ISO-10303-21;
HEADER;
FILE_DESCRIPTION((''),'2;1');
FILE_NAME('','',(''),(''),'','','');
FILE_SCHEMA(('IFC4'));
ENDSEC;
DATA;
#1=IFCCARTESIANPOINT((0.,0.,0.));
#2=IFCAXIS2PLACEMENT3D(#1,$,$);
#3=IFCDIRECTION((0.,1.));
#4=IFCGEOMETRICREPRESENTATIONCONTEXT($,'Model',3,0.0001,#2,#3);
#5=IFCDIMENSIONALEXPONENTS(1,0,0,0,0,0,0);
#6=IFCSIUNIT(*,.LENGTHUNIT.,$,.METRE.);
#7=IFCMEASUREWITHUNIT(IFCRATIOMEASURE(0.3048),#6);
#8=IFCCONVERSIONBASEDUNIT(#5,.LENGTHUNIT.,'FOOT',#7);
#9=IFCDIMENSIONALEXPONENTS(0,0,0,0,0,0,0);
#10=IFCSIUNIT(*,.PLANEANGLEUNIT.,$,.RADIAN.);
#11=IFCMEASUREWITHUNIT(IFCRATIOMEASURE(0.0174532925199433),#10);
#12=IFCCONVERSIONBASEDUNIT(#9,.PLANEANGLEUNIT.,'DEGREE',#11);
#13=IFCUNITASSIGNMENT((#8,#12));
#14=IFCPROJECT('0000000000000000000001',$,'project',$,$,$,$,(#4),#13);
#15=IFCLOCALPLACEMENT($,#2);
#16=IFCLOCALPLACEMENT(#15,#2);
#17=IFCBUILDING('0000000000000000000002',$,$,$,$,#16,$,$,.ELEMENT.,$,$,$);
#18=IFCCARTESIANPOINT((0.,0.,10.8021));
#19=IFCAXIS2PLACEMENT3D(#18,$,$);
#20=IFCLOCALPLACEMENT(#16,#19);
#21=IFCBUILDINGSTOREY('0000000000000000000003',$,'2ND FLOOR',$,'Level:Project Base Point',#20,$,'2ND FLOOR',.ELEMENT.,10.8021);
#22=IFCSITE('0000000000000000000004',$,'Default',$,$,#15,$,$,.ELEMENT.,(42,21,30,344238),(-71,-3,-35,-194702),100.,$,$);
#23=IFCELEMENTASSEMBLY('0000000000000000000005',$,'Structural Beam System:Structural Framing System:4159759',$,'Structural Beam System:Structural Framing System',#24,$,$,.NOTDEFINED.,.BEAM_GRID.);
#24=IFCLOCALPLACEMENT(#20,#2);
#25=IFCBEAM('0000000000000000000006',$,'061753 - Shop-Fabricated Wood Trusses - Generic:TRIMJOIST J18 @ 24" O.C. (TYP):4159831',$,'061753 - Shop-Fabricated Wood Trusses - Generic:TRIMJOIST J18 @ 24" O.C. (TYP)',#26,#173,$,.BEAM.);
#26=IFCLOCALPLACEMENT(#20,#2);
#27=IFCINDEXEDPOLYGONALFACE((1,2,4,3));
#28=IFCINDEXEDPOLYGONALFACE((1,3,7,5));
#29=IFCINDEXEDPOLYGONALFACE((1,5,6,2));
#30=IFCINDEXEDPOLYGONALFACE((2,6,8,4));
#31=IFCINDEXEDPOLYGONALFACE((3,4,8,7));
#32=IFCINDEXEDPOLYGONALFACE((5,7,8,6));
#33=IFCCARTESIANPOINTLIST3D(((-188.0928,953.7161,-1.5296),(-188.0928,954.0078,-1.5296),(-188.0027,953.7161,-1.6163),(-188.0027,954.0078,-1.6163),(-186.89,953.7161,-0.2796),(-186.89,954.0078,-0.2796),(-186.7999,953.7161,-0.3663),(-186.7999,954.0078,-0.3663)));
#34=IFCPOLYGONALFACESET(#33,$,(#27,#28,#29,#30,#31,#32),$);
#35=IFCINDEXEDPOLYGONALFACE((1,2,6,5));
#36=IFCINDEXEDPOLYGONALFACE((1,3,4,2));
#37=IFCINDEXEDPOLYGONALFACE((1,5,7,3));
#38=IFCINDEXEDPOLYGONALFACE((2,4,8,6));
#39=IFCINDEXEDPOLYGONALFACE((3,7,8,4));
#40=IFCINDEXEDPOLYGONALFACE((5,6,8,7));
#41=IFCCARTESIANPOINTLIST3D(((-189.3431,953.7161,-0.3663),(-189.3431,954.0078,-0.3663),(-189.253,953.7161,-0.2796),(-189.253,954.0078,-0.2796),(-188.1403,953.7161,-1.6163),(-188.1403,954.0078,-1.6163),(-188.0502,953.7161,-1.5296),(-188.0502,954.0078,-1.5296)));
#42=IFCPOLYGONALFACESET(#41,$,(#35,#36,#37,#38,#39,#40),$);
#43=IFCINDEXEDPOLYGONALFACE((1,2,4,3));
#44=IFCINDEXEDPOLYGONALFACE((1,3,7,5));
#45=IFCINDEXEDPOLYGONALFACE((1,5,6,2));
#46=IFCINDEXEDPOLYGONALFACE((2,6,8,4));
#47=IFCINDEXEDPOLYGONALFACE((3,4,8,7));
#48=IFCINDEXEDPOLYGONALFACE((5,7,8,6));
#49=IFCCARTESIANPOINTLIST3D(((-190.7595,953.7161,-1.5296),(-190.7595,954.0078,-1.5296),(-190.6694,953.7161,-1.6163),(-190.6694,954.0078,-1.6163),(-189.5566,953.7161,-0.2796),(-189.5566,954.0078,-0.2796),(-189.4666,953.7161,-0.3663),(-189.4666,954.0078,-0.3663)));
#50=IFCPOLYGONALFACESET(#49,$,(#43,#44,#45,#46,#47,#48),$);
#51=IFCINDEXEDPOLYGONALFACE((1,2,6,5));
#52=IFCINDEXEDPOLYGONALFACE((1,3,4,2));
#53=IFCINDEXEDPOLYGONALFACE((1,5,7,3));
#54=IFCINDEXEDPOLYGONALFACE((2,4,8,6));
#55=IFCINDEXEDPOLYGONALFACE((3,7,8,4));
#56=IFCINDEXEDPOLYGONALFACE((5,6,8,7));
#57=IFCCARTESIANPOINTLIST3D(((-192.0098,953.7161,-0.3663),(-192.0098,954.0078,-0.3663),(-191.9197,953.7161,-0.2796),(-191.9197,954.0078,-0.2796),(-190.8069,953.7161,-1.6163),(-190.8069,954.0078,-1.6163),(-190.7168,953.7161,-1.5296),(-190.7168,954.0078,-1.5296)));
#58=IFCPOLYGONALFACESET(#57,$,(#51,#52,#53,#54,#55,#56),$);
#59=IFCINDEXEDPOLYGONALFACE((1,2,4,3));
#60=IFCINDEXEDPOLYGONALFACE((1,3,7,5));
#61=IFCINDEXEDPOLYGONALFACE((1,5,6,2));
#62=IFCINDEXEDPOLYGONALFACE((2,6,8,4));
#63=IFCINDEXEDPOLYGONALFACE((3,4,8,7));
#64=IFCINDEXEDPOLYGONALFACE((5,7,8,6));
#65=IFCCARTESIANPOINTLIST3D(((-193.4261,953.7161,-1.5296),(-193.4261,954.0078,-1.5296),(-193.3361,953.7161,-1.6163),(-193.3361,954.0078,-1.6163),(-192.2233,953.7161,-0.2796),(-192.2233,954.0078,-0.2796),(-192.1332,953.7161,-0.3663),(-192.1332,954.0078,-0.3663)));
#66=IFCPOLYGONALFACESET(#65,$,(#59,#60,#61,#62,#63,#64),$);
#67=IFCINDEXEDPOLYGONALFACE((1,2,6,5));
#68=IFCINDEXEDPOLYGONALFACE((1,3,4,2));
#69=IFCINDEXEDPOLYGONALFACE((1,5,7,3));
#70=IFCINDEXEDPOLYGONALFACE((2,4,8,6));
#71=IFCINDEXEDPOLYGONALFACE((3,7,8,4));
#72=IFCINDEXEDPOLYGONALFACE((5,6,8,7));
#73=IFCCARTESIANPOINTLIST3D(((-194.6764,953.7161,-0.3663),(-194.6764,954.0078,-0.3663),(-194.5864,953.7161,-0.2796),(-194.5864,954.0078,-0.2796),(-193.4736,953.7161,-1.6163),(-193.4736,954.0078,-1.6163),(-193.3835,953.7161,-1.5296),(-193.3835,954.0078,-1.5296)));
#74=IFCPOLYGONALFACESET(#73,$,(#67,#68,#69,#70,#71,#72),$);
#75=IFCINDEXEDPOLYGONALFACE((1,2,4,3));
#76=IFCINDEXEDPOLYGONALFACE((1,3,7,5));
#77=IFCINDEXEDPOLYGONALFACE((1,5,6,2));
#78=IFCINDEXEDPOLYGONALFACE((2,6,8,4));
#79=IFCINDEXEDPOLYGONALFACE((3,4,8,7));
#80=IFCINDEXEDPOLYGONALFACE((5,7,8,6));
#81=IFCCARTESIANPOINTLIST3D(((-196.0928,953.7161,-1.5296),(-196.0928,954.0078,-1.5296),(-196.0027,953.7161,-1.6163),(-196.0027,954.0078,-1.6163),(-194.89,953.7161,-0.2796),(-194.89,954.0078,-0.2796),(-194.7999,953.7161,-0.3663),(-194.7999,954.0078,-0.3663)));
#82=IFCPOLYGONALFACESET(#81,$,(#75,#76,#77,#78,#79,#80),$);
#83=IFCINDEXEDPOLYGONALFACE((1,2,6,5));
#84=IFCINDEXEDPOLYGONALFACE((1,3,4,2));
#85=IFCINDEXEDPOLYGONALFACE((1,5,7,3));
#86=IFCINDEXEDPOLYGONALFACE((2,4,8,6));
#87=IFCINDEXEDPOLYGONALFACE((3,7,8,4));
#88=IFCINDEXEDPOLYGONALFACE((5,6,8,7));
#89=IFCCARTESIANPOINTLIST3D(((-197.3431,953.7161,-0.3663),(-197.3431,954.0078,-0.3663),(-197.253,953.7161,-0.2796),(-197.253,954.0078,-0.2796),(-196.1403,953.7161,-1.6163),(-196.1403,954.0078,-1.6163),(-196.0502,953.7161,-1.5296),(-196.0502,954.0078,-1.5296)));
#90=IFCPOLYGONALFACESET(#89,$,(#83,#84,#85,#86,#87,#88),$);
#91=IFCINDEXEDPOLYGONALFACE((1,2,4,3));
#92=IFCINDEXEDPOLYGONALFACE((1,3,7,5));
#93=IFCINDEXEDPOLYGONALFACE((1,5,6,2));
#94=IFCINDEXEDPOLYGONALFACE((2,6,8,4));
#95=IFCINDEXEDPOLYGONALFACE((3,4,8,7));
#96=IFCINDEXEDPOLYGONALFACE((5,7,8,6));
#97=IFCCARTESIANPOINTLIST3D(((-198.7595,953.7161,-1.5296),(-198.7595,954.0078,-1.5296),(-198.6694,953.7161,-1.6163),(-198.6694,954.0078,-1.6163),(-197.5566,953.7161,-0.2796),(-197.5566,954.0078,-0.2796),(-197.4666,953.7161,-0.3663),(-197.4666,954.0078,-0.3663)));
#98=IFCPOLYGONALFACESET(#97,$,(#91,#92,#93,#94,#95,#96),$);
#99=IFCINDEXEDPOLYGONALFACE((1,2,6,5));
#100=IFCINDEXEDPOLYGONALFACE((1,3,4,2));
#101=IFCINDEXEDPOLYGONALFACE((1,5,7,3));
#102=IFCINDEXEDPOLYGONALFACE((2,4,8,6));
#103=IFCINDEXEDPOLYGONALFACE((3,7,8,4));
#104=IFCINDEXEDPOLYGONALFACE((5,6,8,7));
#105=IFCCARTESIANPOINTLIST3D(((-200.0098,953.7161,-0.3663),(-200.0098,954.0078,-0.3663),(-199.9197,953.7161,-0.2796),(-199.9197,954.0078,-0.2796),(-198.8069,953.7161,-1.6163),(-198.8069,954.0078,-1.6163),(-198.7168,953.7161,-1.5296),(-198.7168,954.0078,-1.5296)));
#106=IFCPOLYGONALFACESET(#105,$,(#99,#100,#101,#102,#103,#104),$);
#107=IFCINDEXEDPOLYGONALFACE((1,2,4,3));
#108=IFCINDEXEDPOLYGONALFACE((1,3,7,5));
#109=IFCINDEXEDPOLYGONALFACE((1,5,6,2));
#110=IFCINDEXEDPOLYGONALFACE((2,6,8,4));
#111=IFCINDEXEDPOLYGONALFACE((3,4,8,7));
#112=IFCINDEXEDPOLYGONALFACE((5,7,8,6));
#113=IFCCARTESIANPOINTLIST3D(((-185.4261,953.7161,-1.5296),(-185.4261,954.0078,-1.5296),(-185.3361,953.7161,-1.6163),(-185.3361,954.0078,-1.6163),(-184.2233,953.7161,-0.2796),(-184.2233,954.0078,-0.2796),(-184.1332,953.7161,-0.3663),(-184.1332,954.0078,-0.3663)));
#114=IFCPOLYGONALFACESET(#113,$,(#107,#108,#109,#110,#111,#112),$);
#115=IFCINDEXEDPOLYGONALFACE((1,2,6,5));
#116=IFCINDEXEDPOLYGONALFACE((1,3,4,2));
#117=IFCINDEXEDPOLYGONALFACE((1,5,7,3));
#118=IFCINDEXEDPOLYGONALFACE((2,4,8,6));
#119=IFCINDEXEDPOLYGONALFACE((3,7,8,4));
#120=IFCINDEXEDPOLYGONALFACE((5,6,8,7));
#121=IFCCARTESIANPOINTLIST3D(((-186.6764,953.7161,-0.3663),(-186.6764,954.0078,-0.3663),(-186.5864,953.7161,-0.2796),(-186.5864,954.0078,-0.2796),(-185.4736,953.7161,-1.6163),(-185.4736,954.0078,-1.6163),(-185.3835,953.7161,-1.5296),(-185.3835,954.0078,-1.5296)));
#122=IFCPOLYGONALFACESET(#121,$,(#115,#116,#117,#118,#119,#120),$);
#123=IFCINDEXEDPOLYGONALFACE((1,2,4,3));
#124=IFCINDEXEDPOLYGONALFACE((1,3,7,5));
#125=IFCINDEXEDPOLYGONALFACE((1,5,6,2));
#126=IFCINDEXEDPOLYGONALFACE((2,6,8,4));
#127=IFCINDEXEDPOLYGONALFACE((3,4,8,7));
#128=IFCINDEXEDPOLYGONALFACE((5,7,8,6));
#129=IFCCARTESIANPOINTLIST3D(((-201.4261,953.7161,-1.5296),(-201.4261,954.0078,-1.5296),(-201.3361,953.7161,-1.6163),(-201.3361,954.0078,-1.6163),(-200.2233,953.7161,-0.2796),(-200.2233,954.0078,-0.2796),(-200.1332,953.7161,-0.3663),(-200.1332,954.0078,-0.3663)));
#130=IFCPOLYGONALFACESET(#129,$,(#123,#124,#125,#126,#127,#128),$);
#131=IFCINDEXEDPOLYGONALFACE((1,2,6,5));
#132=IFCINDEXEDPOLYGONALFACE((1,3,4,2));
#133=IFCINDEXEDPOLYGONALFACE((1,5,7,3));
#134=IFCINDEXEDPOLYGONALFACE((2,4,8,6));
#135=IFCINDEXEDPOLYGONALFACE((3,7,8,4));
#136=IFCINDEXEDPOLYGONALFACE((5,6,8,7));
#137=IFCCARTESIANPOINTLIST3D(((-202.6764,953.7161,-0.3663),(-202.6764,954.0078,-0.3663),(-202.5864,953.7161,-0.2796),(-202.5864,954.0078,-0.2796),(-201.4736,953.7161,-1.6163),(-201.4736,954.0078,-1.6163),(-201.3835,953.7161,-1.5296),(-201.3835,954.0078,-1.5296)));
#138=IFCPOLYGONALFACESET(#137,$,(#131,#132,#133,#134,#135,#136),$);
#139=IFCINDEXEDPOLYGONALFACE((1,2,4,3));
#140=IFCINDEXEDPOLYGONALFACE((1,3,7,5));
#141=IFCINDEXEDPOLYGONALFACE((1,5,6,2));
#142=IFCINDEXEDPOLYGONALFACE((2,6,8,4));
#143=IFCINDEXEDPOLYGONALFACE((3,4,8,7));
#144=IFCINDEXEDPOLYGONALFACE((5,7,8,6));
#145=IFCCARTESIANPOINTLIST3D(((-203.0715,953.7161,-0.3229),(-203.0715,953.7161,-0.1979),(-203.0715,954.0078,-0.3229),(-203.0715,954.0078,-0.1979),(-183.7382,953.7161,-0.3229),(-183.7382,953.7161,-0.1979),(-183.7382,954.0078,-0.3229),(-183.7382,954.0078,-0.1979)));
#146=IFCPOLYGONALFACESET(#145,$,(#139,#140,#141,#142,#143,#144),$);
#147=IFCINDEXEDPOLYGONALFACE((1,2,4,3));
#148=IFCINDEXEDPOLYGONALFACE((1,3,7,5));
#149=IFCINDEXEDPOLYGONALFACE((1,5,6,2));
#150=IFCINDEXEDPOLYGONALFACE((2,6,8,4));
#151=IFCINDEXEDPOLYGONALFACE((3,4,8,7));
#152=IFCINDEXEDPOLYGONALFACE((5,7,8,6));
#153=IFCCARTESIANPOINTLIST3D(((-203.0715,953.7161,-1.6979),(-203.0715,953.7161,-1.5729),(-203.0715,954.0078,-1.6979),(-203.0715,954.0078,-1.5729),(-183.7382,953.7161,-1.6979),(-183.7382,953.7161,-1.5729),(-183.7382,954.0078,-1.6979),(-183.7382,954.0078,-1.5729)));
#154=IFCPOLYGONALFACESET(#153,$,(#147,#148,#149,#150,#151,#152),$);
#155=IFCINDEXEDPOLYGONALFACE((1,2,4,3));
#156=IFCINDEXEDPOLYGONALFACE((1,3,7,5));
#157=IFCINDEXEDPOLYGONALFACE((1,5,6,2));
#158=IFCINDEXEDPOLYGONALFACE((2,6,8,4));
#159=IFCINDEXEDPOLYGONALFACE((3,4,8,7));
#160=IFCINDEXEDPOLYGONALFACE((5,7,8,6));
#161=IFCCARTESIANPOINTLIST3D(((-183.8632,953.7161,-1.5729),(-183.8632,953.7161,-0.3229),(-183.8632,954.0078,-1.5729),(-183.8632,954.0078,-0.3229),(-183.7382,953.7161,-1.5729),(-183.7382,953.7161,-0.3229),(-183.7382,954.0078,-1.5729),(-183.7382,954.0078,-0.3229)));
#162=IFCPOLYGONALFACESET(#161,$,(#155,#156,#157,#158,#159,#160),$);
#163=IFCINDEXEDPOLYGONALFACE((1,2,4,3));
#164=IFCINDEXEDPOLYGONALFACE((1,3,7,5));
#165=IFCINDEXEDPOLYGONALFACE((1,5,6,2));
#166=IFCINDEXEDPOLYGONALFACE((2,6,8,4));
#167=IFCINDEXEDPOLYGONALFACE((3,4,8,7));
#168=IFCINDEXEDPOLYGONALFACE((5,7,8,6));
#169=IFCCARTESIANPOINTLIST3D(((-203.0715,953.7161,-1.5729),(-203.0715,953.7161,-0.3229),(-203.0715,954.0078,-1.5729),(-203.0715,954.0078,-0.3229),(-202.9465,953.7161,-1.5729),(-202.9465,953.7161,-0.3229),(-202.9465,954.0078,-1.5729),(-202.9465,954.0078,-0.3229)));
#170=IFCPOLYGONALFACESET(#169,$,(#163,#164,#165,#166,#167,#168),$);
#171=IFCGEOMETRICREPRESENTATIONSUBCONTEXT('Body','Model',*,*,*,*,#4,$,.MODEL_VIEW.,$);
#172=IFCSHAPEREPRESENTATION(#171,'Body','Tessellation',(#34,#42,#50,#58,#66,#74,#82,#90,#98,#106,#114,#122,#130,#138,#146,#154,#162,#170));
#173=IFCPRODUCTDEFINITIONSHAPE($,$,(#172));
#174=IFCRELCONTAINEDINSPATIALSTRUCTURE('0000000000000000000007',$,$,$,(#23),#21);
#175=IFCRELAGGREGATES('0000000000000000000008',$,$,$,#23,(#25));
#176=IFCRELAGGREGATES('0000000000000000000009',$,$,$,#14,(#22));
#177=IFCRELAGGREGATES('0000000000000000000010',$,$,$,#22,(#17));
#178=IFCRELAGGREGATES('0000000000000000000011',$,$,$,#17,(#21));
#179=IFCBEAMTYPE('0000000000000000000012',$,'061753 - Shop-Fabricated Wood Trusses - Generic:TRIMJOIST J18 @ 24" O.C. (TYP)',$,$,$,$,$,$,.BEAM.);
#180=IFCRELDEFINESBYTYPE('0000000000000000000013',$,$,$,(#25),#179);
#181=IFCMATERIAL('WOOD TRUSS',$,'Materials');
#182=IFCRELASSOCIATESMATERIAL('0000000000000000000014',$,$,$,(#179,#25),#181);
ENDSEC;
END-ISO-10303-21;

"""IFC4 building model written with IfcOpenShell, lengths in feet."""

from ifc_helpers import new_model, entity, si_unit, converted_unit, direction, frame, frame_2d, origin, origin_2d_with_axis, place, context, subcontext, project, spatial, rectangle, extrude, source, transform, mapped, material, material_profile, profile_set, profile_usage, type_object, type_shapes, element, aggregate, save


model = new_model("IFC4")

# Units and contexts
model_context = context("Model", 3, precision=0.0001, world=origin(), true_north=direction((0.0, 1.0)))
body_context = subcontext(model_context, "Body", "Model", "MODEL_VIEW")
ifc_project = project(units=[converted_unit("LENGTHUNIT", "FOOT", entity("IfcRatioMeasure", 0.3048), si_unit("LENGTHUNIT", "METRE"), dimensions=[1, 0, 0, 0, 0, 0, 0]), converted_unit("PLANEANGLEUNIT", "DEGREE", entity("IfcRatioMeasure", 0.0174532925199433), si_unit("PLANEANGLEUNIT", "RADIAN"), dimensions=[0, 0, 0, 0, 0, 0, 0])], contexts=[model_context])

# Site, building, storey
site_placement = place(None, origin())
site = spatial("IfcSite", under=ifc_project, at=site_placement, Name="Default", CompositionType="ELEMENT", RefLatitude=(42, 21, 30, 344238), RefLongitude=(-71, -3, -35, -194702), RefElevation=100.0)
building_placement = place(site_placement, origin())
building = spatial("IfcBuilding", under=site, at=building_placement, CompositionType="ELEMENT")
storey_placement = place(building_placement, frame((0.0, 0.0, 10.8021)))
storey = spatial("IfcBuildingStorey", under=building, at=storey_placement, Name="2ND FLOOR", ObjectType="Level:Project Base Point", LongName="2ND FLOOR", CompositionType="ELEMENT", Elevation=10.8021)

# Element assembly, beam
ifc_material_1 = material(Name="WOOD TRUSS", Category="Materials")
ifc_material_profile_1 = material_profile(ifc_material_1, rectangle(XDim=1.7347, YDim=0.125, at=frame_2d((0.0, 0.0), x_axis=(1.0, 0.0))), Name="TRIMJOIST J18 @ 24\" O.C. (TYP)")
ifc_material_profile_2 = material_profile(ifc_material_1, rectangle(XDim=1.7347, YDim=0.125, at=frame_2d((0.0, 0.0), x_axis=(1.0, 0.0))), Name="TRIMJOIST J18 @ 24\" O.C. (TYP)")
ifc_material_profile_3 = material_profile(ifc_material_1, rectangle(XDim=1.7347, YDim=0.125, at=frame_2d((0.0, 0.0), x_axis=(1.0, 0.0))), Name="TRIMJOIST J18 @ 24\" O.C. (TYP)")
ifc_material_profile_4 = material_profile(ifc_material_1, rectangle(XDim=1.7347, YDim=0.125, at=frame_2d((0.0, 0.0), x_axis=(1.0, 0.0))), Name="TRIMJOIST J18 @ 24\" O.C. (TYP)")
ifc_material_profile_5 = material_profile(ifc_material_1, rectangle(XDim=1.7347, YDim=0.125, at=frame_2d((0.0, 0.0), x_axis=(1.0, 0.0))), Name="TRIMJOIST J18 @ 24\" O.C. (TYP)")
ifc_material_profile_6 = material_profile(ifc_material_1, rectangle(XDim=1.7347, YDim=0.125, at=frame_2d((0.0, 0.0), x_axis=(1.0, 0.0))), Name="TRIMJOIST J18 @ 24\" O.C. (TYP)")
ifc_material_profile_7 = material_profile(ifc_material_1, rectangle(XDim=1.7347, YDim=0.125, at=frame_2d((0.0, 0.0), x_axis=(1.0, 0.0))), Name="TRIMJOIST J18 @ 24\" O.C. (TYP)")
ifc_material_profile_8 = material_profile(ifc_material_1, rectangle(XDim=1.7347, YDim=0.125, at=frame_2d((0.0, 0.0), x_axis=(1.0, 0.0))), Name="TRIMJOIST J18 @ 24\" O.C. (TYP)")
ifc_material_profile_9 = material_profile(ifc_material_1, rectangle(XDim=1.7347, YDim=0.125, at=frame_2d((0.0, 0.0), x_axis=(1.0, 0.0))), Name="TRIMJOIST J18 @ 24\" O.C. (TYP)")
ifc_material_profile_10 = material_profile(ifc_material_1, rectangle(XDim=1.7347, YDim=0.125, at=origin_2d_with_axis()), Name="TRIMJOIST J18 @ 24\" O.C. (TYP)")
ifc_material_profile_11 = material_profile(ifc_material_1, rectangle(XDim=0.125, YDim=0.2917, at=origin_2d_with_axis()), Name="TRIMJOIST J18 @ 24\" O.C. (TYP)")
ifc_material_profile_12 = material_profile(ifc_material_1, rectangle(XDim=0.125, YDim=0.2917, at=origin_2d_with_axis()), Name="TRIMJOIST J18 @ 24\" O.C. (TYP)")
ifc_material_profile_13 = material_profile(ifc_material_1, rectangle(XDim=1.25, YDim=0.2917, at=origin_2d_with_axis()), Name="TRIMJOIST J18 @ 24\" O.C. (TYP)")
ifc_material_profile_14 = material_profile(ifc_material_1, rectangle(XDim=1.25, YDim=0.2917, at=origin_2d_with_axis()), Name="TRIMJOIST J18 @ 24\" O.C. (TYP)")
ifc_profile_set_1 = profile_set([ifc_material_profile_1, ifc_material_profile_2, ifc_material_profile_3, ifc_material_profile_4, ifc_material_profile_5, ifc_material_profile_6, ifc_material_profile_7, ifc_material_profile_8, ifc_material_profile_9, ifc_material_profile_10, ifc_material_profile_11, ifc_material_profile_12, ifc_material_profile_13, ifc_material_profile_14], Name="TRIMJOIST J18 @ 24\" O.C. (TYP)")
beam_type_1 = type_object("IfcBeamType", Name="061753 - Shop-Fabricated Wood Trusses - Generic:TRIMJOIST J18 @ 24\" O.C. (TYP)", PredefinedType="BEAM", material=ifc_profile_set_1)
shared_shape_1 = source(origin(), body_context, "Body", "SweptSolid", [
    extrude(rectangle(XDim=1.7347, YDim=0.125, at=frame_2d((0.0, 0.0), x_axis=(1.0, 0.0))), frame((5.9585, -0.1458, 0.0), z_axis=(0.0, 1.0, 0.0), x_axis=(0.693383, 0.0, 0.720569)), (0.0, 0.0, 1.0), 0.2917),
    extrude(rectangle(XDim=1.7347, YDim=0.125, at=origin_2d_with_axis()), frame((4.7082, -0.1458, 0.0), z_axis=(0.0, 1.0, 0.0), x_axis=(0.693383, 0.0, -0.720569)), (0.0, 0.0, 1.0), 0.2917),
    extrude(rectangle(XDim=1.7347, YDim=0.125, at=frame_2d((0.0, 0.0), x_axis=(1.0, 0.0))), frame((3.2918, -0.1458, 0.0), z_axis=(0.0, 1.0, 0.0), x_axis=(0.693383, 0.0, 0.720569)), (0.0, 0.0, 1.0), 0.2917),
    extrude(rectangle(XDim=1.7347, YDim=0.125, at=frame_2d((0.0, 0.0), x_axis=(1.0, 0.0))), frame((2.0415, -0.1458, 0.0), z_axis=(0.0, 1.0, 0.0), x_axis=(0.693383, 0.0, -0.720569)), (0.0, 0.0, 1.0), 0.2917),
    extrude(rectangle(XDim=1.7347, YDim=0.125, at=frame_2d((0.0, 0.0), x_axis=(1.0, 0.0))), frame((0.6251, -0.1458, 0.0), z_axis=(0.0, 1.0, 0.0), x_axis=(0.693383, 0.0, 0.720569)), (0.0, 0.0, 1.0), 0.2917),
    extrude(rectangle(XDim=1.7347, YDim=0.125, at=frame_2d((0.0, 0.0), x_axis=(1.0, 0.0))), frame((-0.6251, -0.1458, 0.0), z_axis=(0.0, 1.0, 0.0), x_axis=(0.693383, 0.0, -0.720569)), (0.0, 0.0, 1.0), 0.2917),
    extrude(rectangle(XDim=1.7347, YDim=0.125, at=frame_2d((0.0, 0.0), x_axis=(1.0, 0.0))), frame((-2.0415, -0.1458, 0.0), z_axis=(0.0, 1.0, 0.0), x_axis=(0.693383, 0.0, 0.720569)), (0.0, 0.0, 1.0), 0.2917),
    extrude(rectangle(XDim=1.7347, YDim=0.125, at=origin_2d_with_axis()), frame((-3.2918, -0.1458, 0.0), z_axis=(0.0, 1.0, 0.0), x_axis=(0.693383, 0.0, -0.720569)), (0.0, 0.0, 1.0), 0.2917),
    extrude(rectangle(XDim=1.7347, YDim=0.125, at=frame_2d((0.0, 0.0), x_axis=(1.0, 0.0))), frame((-4.7082, -0.1458, 0.0), z_axis=(0.0, 1.0, 0.0), x_axis=(0.693383, 0.0, 0.720569)), (0.0, 0.0, 1.0), 0.2917),
    extrude(rectangle(XDim=1.7347, YDim=0.125, at=frame_2d((0.0, 0.0), x_axis=(1.0, 0.0))), frame((-5.9585, -0.1458, 0.0), z_axis=(0.0, 1.0, 0.0), x_axis=(0.693383, 0.0, -0.720569)), (0.0, 0.0, 1.0), 0.2917),
    extrude(rectangle(XDim=1.7347, YDim=0.125, at=frame_2d((0.0, 0.0), x_axis=(1.0, 0.0))), frame((8.6251, -0.1458, 0.0), z_axis=(0.0, 1.0, 0.0), x_axis=(0.693383, 0.0, 0.720569)), (0.0, 0.0, 1.0), 0.2917),
    extrude(rectangle(XDim=1.7347, YDim=0.125, at=origin_2d_with_axis()), frame((7.3749, -0.1458, 0.0), z_axis=(0.0, 1.0, 0.0), x_axis=(0.693383, 0.0, -0.720569)), (0.0, 0.0, 1.0), 0.2917),
    extrude(rectangle(XDim=1.7347, YDim=0.125, at=frame_2d((0.0, 0.0), x_axis=(1.0, 0.0))), frame((-7.3749, -0.1458, 0.0), z_axis=(0.0, 1.0, 0.0), x_axis=(0.693383, 0.0, 0.720569)), (0.0, 0.0, 1.0), 0.2917),
    extrude(rectangle(XDim=1.7347, YDim=0.125, at=origin_2d_with_axis()), frame((-8.6251, -0.1458, 0.0), z_axis=(0.0, 1.0, 0.0), x_axis=(0.693383, 0.0, -0.720569)), (0.0, 0.0, 1.0), 0.2917),
    extrude(rectangle(XDim=0.125, YDim=0.2917, at=origin_2d_with_axis()), frame((-9.6667, 0.0, 0.6875), z_axis=(1.0, 0.0, 0.0), x_axis=(0.0, 0.0, -1.0)), (0.0, 0.0, 1.0), 19.3333),
    extrude(rectangle(XDim=0.125, YDim=0.2917, at=origin_2d_with_axis()), frame((-9.6667, 0.0, -0.6875), z_axis=(1.0, 0.0, 0.0), x_axis=(0.0, 0.0, -1.0)), (0.0, 0.0, 1.0), 19.3333),
    extrude(rectangle(XDim=1.25, YDim=0.2917, at=origin_2d_with_axis()), frame((9.5417, 0.0, 0.0), z_axis=(1.0, 0.0, 0.0), x_axis=(0.0, 0.0, -1.0)), (0.0, 0.0, 1.0), 0.125),
    extrude(rectangle(XDim=1.25, YDim=0.2917, at=origin_2d_with_axis()), frame((-9.6667, 0.0, 0.0), z_axis=(1.0, 0.0, 0.0), x_axis=(0.0, 0.0, -1.0)), (0.0, 0.0, 1.0), 0.125),
])
type_shapes(beam_type_1, [shared_shape_1])
assembly_1_placement = place(storey_placement, origin())
assembly_1 = element("IfcElementAssembly", 1, at=assembly_1_placement, inside=storey, Name="Structural Beam System:Structural Framing System:4159759", ObjectType="Structural Beam System:Structural Framing System", AssemblyPlace="NOTDEFINED", PredefinedType="BEAM_GRID")
ifc_profile_usage_1 = profile_usage(ifc_profile_set_1, cardinal=8)
beam_1_placement = place(assembly_1_placement, frame((-193.4048, 953.8619, -0.9479)))
beam_1 = element("IfcBeam", 2, at=beam_1_placement, type_object=beam_type_1, material=ifc_profile_usage_1, Name="061753 - Shop-Fabricated Wood Trusses - Generic:TRIMJOIST J18 @ 24\" O.C. (TYP):4159831", ObjectType="061753 - Shop-Fabricated Wood Trusses - Generic:TRIMJOIST J18 @ 24\" O.C. (TYP)", PredefinedType="BEAM", context=body_context, shape_type="MappedRepresentation", body=[
    mapped(shared_shape_1, transform((0.0, 0.0, 0.0), scale=1.0)),
])

aggregate(assembly_1, [beam_1])

save(model, "model.ifc")
